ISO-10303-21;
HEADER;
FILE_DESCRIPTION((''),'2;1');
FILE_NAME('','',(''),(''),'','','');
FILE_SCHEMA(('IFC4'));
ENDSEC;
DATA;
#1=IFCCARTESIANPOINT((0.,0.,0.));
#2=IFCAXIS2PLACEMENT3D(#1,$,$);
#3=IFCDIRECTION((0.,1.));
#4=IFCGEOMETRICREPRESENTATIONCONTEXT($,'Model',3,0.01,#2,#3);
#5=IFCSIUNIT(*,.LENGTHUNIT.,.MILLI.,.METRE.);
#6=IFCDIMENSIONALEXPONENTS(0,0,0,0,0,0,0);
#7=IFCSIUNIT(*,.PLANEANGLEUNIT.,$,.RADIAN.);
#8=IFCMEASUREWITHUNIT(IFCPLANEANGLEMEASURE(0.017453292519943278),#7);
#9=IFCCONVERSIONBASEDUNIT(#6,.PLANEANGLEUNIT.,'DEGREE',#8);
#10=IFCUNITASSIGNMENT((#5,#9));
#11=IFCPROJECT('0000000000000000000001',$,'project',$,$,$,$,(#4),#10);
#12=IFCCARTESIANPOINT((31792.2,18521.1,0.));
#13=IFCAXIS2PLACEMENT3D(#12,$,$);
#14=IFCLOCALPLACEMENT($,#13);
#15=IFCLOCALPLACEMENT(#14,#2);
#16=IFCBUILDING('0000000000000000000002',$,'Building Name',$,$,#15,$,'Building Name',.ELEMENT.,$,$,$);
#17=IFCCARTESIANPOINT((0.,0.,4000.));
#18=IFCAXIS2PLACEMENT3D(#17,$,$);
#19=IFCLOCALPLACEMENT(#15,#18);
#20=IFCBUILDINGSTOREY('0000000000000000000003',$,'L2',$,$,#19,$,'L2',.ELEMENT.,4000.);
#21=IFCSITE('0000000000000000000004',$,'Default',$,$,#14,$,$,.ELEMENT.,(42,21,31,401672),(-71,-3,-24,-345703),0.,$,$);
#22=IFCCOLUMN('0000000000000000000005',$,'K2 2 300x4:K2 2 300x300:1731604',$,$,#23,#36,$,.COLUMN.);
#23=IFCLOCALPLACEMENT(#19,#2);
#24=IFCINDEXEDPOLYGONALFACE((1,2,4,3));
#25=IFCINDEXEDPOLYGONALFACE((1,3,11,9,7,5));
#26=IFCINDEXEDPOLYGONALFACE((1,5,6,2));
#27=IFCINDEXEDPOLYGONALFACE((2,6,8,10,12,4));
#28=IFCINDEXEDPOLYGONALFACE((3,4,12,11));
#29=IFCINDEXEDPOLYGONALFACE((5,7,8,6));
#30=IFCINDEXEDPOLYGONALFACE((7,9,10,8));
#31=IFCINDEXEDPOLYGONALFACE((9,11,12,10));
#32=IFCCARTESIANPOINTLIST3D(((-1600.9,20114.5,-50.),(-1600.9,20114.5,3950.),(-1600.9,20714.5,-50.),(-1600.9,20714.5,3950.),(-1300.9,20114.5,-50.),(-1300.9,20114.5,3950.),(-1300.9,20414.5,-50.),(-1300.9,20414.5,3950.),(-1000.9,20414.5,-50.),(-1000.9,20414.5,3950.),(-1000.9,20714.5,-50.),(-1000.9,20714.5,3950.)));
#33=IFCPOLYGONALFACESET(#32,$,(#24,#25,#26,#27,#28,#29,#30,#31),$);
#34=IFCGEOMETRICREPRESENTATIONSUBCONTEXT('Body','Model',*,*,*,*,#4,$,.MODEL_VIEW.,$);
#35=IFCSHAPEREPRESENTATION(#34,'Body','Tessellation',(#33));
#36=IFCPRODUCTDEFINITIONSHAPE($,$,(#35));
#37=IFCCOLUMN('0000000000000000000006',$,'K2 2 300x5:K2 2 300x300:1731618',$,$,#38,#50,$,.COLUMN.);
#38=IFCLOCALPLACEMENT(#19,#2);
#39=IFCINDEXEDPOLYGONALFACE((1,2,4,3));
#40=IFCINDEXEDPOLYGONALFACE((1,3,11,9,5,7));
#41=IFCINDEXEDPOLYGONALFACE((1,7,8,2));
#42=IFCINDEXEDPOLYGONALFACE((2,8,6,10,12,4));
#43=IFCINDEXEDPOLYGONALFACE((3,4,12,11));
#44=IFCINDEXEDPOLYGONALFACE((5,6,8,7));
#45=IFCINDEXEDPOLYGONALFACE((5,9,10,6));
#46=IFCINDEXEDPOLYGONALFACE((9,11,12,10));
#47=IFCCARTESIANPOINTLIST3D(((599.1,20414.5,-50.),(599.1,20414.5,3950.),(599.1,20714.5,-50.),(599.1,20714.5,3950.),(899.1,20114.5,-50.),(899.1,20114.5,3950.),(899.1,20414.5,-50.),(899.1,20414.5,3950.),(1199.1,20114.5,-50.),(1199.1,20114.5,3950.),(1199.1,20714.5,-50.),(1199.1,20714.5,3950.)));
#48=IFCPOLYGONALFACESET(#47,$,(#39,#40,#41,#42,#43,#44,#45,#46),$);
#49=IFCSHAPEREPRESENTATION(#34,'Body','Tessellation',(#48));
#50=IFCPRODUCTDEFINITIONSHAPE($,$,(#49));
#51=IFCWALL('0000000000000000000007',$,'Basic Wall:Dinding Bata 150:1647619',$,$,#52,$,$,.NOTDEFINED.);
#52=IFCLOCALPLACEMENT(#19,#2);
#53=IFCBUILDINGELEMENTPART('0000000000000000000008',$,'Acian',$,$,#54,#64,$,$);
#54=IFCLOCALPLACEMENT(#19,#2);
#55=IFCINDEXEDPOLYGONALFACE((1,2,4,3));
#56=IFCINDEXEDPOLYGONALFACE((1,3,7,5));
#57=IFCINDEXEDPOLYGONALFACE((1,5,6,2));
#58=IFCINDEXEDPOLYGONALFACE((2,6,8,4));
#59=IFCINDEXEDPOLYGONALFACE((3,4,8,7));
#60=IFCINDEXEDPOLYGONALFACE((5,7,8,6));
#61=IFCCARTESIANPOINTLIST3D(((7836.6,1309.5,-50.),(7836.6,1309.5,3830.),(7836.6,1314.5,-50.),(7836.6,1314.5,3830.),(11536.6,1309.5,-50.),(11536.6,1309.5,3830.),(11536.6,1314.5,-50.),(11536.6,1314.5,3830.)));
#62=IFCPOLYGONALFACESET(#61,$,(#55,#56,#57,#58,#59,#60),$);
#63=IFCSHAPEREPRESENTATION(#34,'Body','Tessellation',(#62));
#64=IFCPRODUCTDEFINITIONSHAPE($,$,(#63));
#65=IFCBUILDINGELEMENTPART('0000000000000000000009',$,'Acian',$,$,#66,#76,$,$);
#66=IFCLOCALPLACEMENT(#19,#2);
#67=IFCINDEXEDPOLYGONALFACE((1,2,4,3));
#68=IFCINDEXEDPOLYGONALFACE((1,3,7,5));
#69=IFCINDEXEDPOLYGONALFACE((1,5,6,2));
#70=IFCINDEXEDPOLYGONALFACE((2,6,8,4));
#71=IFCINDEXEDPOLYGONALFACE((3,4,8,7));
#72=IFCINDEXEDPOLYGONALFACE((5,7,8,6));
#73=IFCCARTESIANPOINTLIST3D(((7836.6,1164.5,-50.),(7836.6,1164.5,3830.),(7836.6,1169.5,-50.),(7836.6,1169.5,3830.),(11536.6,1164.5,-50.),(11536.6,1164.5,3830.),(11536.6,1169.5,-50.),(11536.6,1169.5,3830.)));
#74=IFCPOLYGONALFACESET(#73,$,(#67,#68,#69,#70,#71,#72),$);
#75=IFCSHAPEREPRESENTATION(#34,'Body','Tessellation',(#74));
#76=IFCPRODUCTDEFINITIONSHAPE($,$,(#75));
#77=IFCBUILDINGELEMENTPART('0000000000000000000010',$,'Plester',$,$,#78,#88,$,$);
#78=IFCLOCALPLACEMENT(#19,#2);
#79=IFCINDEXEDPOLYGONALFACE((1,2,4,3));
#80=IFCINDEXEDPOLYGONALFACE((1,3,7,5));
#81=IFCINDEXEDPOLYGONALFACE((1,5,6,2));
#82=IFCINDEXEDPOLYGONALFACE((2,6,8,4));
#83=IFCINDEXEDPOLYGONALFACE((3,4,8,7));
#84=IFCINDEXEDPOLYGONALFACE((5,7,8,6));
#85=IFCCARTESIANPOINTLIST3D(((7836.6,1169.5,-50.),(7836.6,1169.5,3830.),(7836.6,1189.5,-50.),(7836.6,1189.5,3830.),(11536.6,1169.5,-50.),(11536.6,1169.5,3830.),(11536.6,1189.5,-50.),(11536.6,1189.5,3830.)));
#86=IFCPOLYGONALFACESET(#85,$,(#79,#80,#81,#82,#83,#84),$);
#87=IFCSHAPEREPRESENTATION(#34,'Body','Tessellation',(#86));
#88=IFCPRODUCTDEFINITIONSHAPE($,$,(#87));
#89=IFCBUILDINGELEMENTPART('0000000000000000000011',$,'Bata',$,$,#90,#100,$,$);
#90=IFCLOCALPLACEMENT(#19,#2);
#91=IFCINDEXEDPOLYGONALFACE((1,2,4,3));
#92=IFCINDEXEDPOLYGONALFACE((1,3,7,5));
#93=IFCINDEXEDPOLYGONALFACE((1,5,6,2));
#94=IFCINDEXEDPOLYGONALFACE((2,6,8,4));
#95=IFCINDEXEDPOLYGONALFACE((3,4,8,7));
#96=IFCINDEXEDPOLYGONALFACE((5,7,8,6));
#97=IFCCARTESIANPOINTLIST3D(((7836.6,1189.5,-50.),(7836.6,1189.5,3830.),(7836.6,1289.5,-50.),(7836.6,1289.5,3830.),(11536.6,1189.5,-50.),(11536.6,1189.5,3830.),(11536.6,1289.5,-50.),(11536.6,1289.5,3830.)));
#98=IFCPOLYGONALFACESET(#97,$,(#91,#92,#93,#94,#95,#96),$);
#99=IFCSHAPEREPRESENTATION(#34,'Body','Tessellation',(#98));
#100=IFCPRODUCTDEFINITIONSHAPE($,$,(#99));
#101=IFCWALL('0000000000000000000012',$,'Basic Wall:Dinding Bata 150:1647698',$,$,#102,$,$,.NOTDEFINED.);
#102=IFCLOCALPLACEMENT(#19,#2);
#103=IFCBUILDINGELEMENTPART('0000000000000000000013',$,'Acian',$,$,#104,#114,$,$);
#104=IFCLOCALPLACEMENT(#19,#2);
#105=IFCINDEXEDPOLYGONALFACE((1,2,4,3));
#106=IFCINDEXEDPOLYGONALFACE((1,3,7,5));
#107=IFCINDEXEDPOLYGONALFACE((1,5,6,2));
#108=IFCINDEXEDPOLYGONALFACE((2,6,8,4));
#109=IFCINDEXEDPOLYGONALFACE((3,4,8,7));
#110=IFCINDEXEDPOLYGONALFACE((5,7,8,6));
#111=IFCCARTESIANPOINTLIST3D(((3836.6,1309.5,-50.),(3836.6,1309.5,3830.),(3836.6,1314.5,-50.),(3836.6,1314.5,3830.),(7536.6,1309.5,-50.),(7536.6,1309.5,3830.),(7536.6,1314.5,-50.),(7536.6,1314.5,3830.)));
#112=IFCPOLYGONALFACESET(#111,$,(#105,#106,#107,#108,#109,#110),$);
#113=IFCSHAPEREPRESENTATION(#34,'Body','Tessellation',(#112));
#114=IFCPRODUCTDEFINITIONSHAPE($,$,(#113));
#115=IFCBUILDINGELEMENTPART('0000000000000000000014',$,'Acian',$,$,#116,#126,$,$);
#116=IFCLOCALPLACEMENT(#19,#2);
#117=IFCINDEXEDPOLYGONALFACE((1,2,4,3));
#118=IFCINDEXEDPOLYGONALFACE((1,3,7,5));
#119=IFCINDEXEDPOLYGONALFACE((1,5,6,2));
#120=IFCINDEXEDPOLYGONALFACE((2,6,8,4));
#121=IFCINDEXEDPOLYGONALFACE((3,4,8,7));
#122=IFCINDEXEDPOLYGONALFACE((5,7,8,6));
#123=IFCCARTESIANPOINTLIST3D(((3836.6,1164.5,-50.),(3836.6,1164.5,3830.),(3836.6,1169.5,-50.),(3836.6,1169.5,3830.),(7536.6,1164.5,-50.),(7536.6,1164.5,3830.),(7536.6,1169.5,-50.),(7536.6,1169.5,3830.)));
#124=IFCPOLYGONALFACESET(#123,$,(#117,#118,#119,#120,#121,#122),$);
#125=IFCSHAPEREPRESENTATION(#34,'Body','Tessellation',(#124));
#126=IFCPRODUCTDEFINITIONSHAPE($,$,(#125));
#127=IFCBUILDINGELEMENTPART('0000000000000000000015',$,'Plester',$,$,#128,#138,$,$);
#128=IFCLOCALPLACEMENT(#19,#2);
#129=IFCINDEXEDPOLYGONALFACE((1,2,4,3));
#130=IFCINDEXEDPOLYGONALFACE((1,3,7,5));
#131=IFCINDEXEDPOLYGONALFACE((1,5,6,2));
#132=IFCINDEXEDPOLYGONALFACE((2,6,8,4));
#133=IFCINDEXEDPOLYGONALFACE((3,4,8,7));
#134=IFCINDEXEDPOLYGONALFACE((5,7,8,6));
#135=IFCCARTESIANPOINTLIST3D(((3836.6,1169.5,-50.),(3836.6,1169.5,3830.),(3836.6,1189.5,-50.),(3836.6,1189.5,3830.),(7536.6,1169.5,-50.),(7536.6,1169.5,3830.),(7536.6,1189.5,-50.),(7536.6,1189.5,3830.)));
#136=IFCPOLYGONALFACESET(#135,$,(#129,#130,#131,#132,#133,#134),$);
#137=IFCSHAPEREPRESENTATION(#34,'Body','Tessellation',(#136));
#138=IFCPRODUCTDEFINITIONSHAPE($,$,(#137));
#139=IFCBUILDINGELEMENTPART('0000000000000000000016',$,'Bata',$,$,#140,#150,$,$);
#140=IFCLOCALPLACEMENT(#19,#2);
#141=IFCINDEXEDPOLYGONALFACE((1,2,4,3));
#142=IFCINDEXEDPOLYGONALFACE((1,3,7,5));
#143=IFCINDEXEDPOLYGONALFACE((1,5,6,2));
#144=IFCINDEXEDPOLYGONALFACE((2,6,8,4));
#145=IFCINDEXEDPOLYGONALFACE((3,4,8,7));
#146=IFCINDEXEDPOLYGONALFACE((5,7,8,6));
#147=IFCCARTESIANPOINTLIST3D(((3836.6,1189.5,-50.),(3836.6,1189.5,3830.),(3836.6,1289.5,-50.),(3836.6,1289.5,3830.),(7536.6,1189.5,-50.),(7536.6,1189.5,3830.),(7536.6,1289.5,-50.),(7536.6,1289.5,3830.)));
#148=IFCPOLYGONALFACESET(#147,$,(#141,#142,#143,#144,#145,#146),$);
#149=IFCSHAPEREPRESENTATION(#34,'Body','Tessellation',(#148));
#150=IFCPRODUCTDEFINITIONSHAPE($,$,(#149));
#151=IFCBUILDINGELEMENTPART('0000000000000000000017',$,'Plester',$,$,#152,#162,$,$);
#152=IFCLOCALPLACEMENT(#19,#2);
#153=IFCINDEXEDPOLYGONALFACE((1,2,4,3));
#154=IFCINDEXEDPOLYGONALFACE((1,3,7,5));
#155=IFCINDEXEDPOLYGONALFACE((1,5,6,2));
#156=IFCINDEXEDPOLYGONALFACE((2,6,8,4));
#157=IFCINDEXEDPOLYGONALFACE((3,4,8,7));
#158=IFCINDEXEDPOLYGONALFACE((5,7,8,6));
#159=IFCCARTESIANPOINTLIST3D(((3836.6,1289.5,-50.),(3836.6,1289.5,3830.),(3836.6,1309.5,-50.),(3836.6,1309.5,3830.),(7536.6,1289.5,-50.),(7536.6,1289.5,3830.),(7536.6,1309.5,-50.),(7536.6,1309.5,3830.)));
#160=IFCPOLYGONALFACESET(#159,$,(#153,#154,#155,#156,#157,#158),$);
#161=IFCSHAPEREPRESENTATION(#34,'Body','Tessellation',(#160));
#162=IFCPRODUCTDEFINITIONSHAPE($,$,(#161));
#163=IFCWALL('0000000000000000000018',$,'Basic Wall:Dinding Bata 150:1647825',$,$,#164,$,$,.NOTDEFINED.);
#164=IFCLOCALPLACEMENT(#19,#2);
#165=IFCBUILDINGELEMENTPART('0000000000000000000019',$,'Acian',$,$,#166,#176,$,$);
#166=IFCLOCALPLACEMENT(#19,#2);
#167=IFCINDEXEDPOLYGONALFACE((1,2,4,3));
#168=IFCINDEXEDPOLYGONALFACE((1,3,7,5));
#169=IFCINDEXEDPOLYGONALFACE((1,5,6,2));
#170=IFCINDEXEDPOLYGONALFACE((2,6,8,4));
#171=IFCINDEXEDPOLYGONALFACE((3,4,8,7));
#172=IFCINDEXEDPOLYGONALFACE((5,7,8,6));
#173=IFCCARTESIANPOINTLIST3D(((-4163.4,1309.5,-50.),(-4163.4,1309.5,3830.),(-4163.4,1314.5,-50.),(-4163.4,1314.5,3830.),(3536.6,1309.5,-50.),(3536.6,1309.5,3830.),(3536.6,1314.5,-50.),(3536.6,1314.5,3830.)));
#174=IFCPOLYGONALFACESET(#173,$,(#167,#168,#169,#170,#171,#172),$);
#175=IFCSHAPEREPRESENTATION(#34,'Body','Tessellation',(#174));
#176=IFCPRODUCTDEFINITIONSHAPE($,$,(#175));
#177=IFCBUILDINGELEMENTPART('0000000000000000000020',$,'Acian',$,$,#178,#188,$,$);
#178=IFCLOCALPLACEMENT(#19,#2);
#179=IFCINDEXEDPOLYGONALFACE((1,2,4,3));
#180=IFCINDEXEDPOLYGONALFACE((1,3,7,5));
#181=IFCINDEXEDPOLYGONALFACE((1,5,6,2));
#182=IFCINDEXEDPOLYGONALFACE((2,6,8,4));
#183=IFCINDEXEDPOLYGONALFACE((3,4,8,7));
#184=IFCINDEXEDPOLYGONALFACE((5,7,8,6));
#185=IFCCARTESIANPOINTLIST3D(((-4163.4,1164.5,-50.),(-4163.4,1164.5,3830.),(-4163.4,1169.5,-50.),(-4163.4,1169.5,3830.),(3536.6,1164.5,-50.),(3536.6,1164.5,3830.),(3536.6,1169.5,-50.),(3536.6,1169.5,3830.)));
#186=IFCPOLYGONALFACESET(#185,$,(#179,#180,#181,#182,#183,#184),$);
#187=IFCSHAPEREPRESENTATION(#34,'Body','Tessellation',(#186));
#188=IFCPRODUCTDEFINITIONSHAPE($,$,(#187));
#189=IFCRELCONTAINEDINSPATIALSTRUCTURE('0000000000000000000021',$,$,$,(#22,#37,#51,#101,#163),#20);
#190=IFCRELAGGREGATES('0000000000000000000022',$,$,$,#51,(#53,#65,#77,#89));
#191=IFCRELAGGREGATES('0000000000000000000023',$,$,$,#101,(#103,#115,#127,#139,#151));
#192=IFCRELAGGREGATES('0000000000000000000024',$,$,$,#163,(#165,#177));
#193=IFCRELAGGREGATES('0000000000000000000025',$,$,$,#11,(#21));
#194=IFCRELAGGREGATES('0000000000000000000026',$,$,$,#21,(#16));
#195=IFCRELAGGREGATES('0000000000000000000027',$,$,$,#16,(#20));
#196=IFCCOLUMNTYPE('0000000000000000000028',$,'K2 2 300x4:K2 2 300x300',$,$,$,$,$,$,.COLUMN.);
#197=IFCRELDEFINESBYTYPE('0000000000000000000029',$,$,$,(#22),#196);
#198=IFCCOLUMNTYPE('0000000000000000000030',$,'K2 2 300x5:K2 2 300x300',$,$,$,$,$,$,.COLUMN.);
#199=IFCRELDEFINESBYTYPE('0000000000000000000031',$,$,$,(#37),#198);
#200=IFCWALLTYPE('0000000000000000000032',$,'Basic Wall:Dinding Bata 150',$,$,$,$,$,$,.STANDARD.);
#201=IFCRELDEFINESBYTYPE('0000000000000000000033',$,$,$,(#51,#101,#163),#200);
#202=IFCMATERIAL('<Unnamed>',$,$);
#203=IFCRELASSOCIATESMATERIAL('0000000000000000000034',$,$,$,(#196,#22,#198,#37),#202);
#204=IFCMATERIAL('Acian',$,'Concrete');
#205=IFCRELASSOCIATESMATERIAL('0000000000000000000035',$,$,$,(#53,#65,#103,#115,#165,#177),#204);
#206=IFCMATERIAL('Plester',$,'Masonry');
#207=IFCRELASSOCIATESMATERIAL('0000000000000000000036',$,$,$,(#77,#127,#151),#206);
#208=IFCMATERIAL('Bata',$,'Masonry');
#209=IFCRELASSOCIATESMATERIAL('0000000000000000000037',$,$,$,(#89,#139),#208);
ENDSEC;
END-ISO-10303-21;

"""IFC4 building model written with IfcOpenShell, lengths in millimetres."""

from ifc_helpers import new_model, entity, si_unit, converted_unit, direction, frame, origin, place, context, subcontext, project, spatial, indexed_curve, outline, extrude, source, transform, mapped, material, type_object, type_shapes, element, aggregate, save


model = new_model("IFC4")

# Units and contexts
model_context = context("Model", 3, precision=0.01, world=origin(), true_north=direction((0.0, 1.0)))
body_context = subcontext(model_context, "Body", "Model", "MODEL_VIEW")
ifc_project = project(units=[si_unit("LENGTHUNIT", "METRE", prefix="MILLI"), converted_unit("PLANEANGLEUNIT", "DEGREE", entity("IfcPlaneAngleMeasure", 0.017453292519943278), si_unit("PLANEANGLEUNIT", "RADIAN"), dimensions=[0, 0, 0, 0, 0, 0, 0])], contexts=[model_context])

# Site, building, storey
site_placement = place(None, frame((31792.2, 18521.1, 0.0)))
site = spatial("IfcSite", under=ifc_project, at=site_placement, Name="Default", CompositionType="ELEMENT", RefLatitude=(42, 21, 31, 401672), RefLongitude=(-71, -3, -24, -345703), RefElevation=0.0)
building_placement = place(site_placement, origin())
building = spatial("IfcBuilding", under=site, at=building_placement, Name="Building Name", LongName="Building Name", CompositionType="ELEMENT")
storey_placement = place(building_placement, frame((0.0, 0.0, 4000.0)))
storey = spatial("IfcBuildingStorey", under=building, at=storey_placement, Name="L2", LongName="L2", CompositionType="ELEMENT", Elevation=4000.0)

# Columns
ifc_material_1 = material(Name="<Unnamed>")
column_type_1 = type_object("IfcColumnType", Name="K2 2 300x4:K2 2 300x300", PredefinedType="COLUMN", material=ifc_material_1)
shared_shape_1 = source(origin(), body_context, "Body", "SweptSolid", [
    extrude(outline(indexed_curve([(0.0, -300.0), (300.0, -300.0), (300.0, 300.0), (-300.0, 300.0), (-300.0, 0.0), (0.0, 0.0), (0.0, -300.0)], self_intersect=False)), frame((-1300.9, 20414.5, 3950.0), z_axis=(0.0, 0.0, 1.0), x_axis=(0.0, 1.0, 0.0)), (0.0, 0.0, 1.0), 4000.0),
])
type_shapes(column_type_1, [shared_shape_1])
column_1_placement = place(storey_placement, frame((0.0, 0.0, -4000.0)))
element("IfcColumn", 1, at=column_1_placement, inside=storey, type_object=column_type_1, material=ifc_material_1, Name="K2 2 300x4:K2 2 300x300:1731604", PredefinedType="COLUMN", context=body_context, shape_type="MappedRepresentation", body=[
    mapped(shared_shape_1, transform((0.0, 0.0, 0.0), scale=1.0)),
])
column_type_2 = type_object("IfcColumnType", Name="K2 2 300x5:K2 2 300x300", PredefinedType="COLUMN", material=ifc_material_1)
shared_shape_2 = source(origin(), body_context, "Body", "SweptSolid", [
    extrude(outline(indexed_curve([(-300.0, 0.0), (-300.0, -300.0), (300.0, -300.0), (300.0, 300.0), (0.0, 300.0), (0.0, 0.0), (-300.0, 0.0)], self_intersect=False)), frame((674.1, 20414.5, 3950.0), z_axis=(0.0, 0.0, -1.0), x_axis=(1.0, 0.0, 0.0)), (0.0, 0.0, -1.0), 4000.0),
])
type_shapes(column_type_2, [shared_shape_2])
column_2_placement = place(storey_placement, frame((225.0, 0.0, -4000.0)))
element("IfcColumn", 2, at=column_2_placement, inside=storey, type_object=column_type_2, material=ifc_material_1, Name="K2 2 300x5:K2 2 300x300:1731618", PredefinedType="COLUMN", context=body_context, shape_type="MappedRepresentation", body=[
    mapped(shared_shape_2, transform((0.0, 0.0, 0.0), scale=1.0)),
])

# Walls, building element parts
wall_type_1 = type_object("IfcWallType", Name="Basic Wall:Dinding Bata 150", PredefinedType="STANDARD")
wall_1_placement = place(storey_placement, frame((11536.6, 1239.5, -50.0), z_axis=(0.0, 0.0, 1.0), x_axis=(-1.0, 0.0, 0.0)))
wall_1 = element("IfcWall", 3, at=wall_1_placement, inside=storey, type_object=wall_type_1, Name="Basic Wall:Dinding Bata 150:1647619", PredefinedType="NOTDEFINED")
ifc_material_2 = material(Name="Acian", Category="Concrete")
building_element_part_1_placement = place(wall_1_placement, origin())
building_element_part_1 = element("IfcBuildingElementPart", 4, at=building_element_part_1_placement, material=ifc_material_2, Name="Acian", context=body_context, shape_type="SweptSolid", body=[
    extrude(outline(indexed_curve([(-2.5, -1850.0), (2.5, -1850.0), (2.5, 1850.0), (-2.5, 1850.0), (-2.5, -1850.0)], self_intersect=False)), frame((1850.0, -72.5, 0.0), z_axis=(0.0, 0.0, 1.0), x_axis=(0.0, 1.0, 0.0)), (0.0, 0.0, 1.0), 3880.0),
])
building_element_part_2_placement = place(wall_1_placement, origin())
building_element_part_2 = element("IfcBuildingElementPart", 5, at=building_element_part_2_placement, material=ifc_material_2, Name="Acian", context=body_context, shape_type="SweptSolid", body=[
    extrude(outline(indexed_curve([(-2.5, -1850.0), (2.5, -1850.0), (2.5, 1850.0), (-2.5, 1850.0), (-2.5, -1850.0)], self_intersect=False)), frame((1850.0, 72.5, 0.0), z_axis=(0.0, 0.0, 1.0), x_axis=(0.0, 1.0, 0.0)), (0.0, 0.0, 1.0), 3880.0),
])
ifc_material_3 = material(Name="Plester", Category="Masonry")
building_element_part_3_placement = place(wall_1_placement, origin())
building_element_part_3 = element("IfcBuildingElementPart", 6, at=building_element_part_3_placement, material=ifc_material_3, Name="Plester", context=body_context, shape_type="SweptSolid", body=[
    extrude(outline(indexed_curve([(-10.0, -1850.0), (10.0, -1850.0), (10.0, 1850.0), (-10.0, 1850.0), (-10.0, -1850.0)], self_intersect=False)), frame((1850.0, 60.0, 0.0), z_axis=(0.0, 0.0, 1.0), x_axis=(0.0, 1.0, 0.0)), (0.0, 0.0, 1.0), 3880.0),
])
ifc_material_4 = material(Name="Bata", Category="Masonry")
building_element_part_4_placement = place(wall_1_placement, origin())
building_element_part_4 = element("IfcBuildingElementPart", 7, at=building_element_part_4_placement, material=ifc_material_4, Name="Bata", context=body_context, shape_type="SweptSolid", body=[
    extrude(outline(indexed_curve([(-50.0, -1850.0), (50.0, -1850.0), (50.0, 1850.0), (-50.0, 1850.0), (-50.0, -1850.0)], self_intersect=False)), frame((1850.0, 0.0, 0.0), z_axis=(0.0, 0.0, 1.0), x_axis=(0.0, 1.0, 0.0)), (0.0, 0.0, 1.0), 3880.0),
])
aggregate(wall_1, [building_element_part_1, building_element_part_2, building_element_part_3, building_element_part_4])
wall_2_placement = place(storey_placement, frame((7536.6, 1239.5, -50.0), z_axis=(0.0, 0.0, 1.0), x_axis=(-1.0, 0.0, 0.0)))
wall_2 = element("IfcWall", 8, at=wall_2_placement, inside=storey, type_object=wall_type_1, Name="Basic Wall:Dinding Bata 150:1647698", PredefinedType="NOTDEFINED")
building_element_part_5_placement = place(wall_2_placement, origin())
building_element_part_5 = element("IfcBuildingElementPart", 9, at=building_element_part_5_placement, material=ifc_material_2, Name="Acian", context=body_context, shape_type="SweptSolid", body=[
    extrude(outline(indexed_curve([(-2.5, -1850.0), (2.5, -1850.0), (2.5, 1850.0), (-2.5, 1850.0), (-2.5, -1850.0)], self_intersect=False)), frame((1850.0, -72.5, 0.0), z_axis=(0.0, 0.0, 1.0), x_axis=(0.0, 1.0, 0.0)), (0.0, 0.0, 1.0), 3880.0),
])
building_element_part_6_placement = place(wall_2_placement, origin())
building_element_part_6 = element("IfcBuildingElementPart", 10, at=building_element_part_6_placement, material=ifc_material_2, Name="Acian", context=body_context, shape_type="SweptSolid", body=[
    extrude(outline(indexed_curve([(-2.5, -1850.0), (2.5, -1850.0), (2.5, 1850.0), (-2.5, 1850.0), (-2.5, -1850.0)], self_intersect=False)), frame((1850.0, 72.5, 0.0), z_axis=(0.0, 0.0, 1.0), x_axis=(0.0, 1.0, 0.0)), (0.0, 0.0, 1.0), 3880.0),
])
building_element_part_7_placement = place(wall_2_placement, origin())
building_element_part_7 = element("IfcBuildingElementPart", 11, at=building_element_part_7_placement, material=ifc_material_3, Name="Plester", context=body_context, shape_type="SweptSolid", body=[
    extrude(outline(indexed_curve([(-10.0, -1850.0), (10.0, -1850.0), (10.0, 1850.0), (-10.0, 1850.0), (-10.0, -1850.0)], self_intersect=False)), frame((1850.0, 60.0, 0.0), z_axis=(0.0, 0.0, 1.0), x_axis=(0.0, 1.0, 0.0)), (0.0, 0.0, 1.0), 3880.0),
])
building_element_part_8_placement = place(wall_2_placement, origin())
building_element_part_8 = element("IfcBuildingElementPart", 12, at=building_element_part_8_placement, material=ifc_material_4, Name="Bata", context=body_context, shape_type="SweptSolid", body=[
    extrude(outline(indexed_curve([(-50.0, -1850.0), (50.0, -1850.0), (50.0, 1850.0), (-50.0, 1850.0), (-50.0, -1850.0)], self_intersect=False)), frame((1850.0, 0.0, 0.0), z_axis=(0.0, 0.0, 1.0), x_axis=(0.0, 1.0, 0.0)), (0.0, 0.0, 1.0), 3880.0),
])
building_element_part_9_placement = place(wall_2_placement, origin())
building_element_part_9 = element("IfcBuildingElementPart", 13, at=building_element_part_9_placement, material=ifc_material_3, Name="Plester", context=body_context, shape_type="SweptSolid", body=[
    extrude(outline(indexed_curve([(-10.0, -1850.0), (10.0, -1850.0), (10.0, 1850.0), (-10.0, 1850.0), (-10.0, -1850.0)], self_intersect=False)), frame((1850.0, -60.0, 0.0), z_axis=(0.0, 0.0, 1.0), x_axis=(0.0, 1.0, 0.0)), (0.0, 0.0, 1.0), 3880.0),
])
aggregate(wall_2, [building_element_part_5, building_element_part_6, building_element_part_7, building_element_part_8, building_element_part_9])
wall_3_placement = place(storey_placement, frame((3536.6, 1239.5, -50.0), z_axis=(0.0, 0.0, 1.0), x_axis=(-1.0, 0.0, 0.0)))
wall_3 = element("IfcWall", 14, at=wall_3_placement, inside=storey, type_object=wall_type_1, Name="Basic Wall:Dinding Bata 150:1647825", PredefinedType="NOTDEFINED")
building_element_part_10_placement = place(wall_3_placement, origin())
building_element_part_10 = element("IfcBuildingElementPart", 15, at=building_element_part_10_placement, material=ifc_material_2, Name="Acian", context=body_context, shape_type="SweptSolid", body=[
    extrude(outline(indexed_curve([(-2.5, -3850.0), (2.5, -3850.0), (2.5, 3850.0), (-2.5, 3850.0), (-2.5, -3850.0)], self_intersect=False)), frame((3850.0, -72.5, 0.0), z_axis=(0.0, 0.0, 1.0), x_axis=(0.0, 1.0, 0.0)), (0.0, 0.0, 1.0), 3880.0),
])
building_element_part_11_placement = place(wall_3_placement, origin())
building_element_part_11 = element("IfcBuildingElementPart", 16, at=building_element_part_11_placement, material=ifc_material_2, Name="Acian", context=body_context, shape_type="SweptSolid", body=[
    extrude(outline(indexed_curve([(-2.5, -3850.0), (2.5, -3850.0), (2.5, 3850.0), (-2.5, 3850.0), (-2.5, -3850.0)], self_intersect=False)), frame((3850.0, 72.5, 0.0), z_axis=(0.0, 0.0, 1.0), x_axis=(0.0, 1.0, 0.0)), (0.0, 0.0, 1.0), 3880.0),
])
aggregate(wall_3, [building_element_part_10, building_element_part_11])

save(model, "model.ifc")
